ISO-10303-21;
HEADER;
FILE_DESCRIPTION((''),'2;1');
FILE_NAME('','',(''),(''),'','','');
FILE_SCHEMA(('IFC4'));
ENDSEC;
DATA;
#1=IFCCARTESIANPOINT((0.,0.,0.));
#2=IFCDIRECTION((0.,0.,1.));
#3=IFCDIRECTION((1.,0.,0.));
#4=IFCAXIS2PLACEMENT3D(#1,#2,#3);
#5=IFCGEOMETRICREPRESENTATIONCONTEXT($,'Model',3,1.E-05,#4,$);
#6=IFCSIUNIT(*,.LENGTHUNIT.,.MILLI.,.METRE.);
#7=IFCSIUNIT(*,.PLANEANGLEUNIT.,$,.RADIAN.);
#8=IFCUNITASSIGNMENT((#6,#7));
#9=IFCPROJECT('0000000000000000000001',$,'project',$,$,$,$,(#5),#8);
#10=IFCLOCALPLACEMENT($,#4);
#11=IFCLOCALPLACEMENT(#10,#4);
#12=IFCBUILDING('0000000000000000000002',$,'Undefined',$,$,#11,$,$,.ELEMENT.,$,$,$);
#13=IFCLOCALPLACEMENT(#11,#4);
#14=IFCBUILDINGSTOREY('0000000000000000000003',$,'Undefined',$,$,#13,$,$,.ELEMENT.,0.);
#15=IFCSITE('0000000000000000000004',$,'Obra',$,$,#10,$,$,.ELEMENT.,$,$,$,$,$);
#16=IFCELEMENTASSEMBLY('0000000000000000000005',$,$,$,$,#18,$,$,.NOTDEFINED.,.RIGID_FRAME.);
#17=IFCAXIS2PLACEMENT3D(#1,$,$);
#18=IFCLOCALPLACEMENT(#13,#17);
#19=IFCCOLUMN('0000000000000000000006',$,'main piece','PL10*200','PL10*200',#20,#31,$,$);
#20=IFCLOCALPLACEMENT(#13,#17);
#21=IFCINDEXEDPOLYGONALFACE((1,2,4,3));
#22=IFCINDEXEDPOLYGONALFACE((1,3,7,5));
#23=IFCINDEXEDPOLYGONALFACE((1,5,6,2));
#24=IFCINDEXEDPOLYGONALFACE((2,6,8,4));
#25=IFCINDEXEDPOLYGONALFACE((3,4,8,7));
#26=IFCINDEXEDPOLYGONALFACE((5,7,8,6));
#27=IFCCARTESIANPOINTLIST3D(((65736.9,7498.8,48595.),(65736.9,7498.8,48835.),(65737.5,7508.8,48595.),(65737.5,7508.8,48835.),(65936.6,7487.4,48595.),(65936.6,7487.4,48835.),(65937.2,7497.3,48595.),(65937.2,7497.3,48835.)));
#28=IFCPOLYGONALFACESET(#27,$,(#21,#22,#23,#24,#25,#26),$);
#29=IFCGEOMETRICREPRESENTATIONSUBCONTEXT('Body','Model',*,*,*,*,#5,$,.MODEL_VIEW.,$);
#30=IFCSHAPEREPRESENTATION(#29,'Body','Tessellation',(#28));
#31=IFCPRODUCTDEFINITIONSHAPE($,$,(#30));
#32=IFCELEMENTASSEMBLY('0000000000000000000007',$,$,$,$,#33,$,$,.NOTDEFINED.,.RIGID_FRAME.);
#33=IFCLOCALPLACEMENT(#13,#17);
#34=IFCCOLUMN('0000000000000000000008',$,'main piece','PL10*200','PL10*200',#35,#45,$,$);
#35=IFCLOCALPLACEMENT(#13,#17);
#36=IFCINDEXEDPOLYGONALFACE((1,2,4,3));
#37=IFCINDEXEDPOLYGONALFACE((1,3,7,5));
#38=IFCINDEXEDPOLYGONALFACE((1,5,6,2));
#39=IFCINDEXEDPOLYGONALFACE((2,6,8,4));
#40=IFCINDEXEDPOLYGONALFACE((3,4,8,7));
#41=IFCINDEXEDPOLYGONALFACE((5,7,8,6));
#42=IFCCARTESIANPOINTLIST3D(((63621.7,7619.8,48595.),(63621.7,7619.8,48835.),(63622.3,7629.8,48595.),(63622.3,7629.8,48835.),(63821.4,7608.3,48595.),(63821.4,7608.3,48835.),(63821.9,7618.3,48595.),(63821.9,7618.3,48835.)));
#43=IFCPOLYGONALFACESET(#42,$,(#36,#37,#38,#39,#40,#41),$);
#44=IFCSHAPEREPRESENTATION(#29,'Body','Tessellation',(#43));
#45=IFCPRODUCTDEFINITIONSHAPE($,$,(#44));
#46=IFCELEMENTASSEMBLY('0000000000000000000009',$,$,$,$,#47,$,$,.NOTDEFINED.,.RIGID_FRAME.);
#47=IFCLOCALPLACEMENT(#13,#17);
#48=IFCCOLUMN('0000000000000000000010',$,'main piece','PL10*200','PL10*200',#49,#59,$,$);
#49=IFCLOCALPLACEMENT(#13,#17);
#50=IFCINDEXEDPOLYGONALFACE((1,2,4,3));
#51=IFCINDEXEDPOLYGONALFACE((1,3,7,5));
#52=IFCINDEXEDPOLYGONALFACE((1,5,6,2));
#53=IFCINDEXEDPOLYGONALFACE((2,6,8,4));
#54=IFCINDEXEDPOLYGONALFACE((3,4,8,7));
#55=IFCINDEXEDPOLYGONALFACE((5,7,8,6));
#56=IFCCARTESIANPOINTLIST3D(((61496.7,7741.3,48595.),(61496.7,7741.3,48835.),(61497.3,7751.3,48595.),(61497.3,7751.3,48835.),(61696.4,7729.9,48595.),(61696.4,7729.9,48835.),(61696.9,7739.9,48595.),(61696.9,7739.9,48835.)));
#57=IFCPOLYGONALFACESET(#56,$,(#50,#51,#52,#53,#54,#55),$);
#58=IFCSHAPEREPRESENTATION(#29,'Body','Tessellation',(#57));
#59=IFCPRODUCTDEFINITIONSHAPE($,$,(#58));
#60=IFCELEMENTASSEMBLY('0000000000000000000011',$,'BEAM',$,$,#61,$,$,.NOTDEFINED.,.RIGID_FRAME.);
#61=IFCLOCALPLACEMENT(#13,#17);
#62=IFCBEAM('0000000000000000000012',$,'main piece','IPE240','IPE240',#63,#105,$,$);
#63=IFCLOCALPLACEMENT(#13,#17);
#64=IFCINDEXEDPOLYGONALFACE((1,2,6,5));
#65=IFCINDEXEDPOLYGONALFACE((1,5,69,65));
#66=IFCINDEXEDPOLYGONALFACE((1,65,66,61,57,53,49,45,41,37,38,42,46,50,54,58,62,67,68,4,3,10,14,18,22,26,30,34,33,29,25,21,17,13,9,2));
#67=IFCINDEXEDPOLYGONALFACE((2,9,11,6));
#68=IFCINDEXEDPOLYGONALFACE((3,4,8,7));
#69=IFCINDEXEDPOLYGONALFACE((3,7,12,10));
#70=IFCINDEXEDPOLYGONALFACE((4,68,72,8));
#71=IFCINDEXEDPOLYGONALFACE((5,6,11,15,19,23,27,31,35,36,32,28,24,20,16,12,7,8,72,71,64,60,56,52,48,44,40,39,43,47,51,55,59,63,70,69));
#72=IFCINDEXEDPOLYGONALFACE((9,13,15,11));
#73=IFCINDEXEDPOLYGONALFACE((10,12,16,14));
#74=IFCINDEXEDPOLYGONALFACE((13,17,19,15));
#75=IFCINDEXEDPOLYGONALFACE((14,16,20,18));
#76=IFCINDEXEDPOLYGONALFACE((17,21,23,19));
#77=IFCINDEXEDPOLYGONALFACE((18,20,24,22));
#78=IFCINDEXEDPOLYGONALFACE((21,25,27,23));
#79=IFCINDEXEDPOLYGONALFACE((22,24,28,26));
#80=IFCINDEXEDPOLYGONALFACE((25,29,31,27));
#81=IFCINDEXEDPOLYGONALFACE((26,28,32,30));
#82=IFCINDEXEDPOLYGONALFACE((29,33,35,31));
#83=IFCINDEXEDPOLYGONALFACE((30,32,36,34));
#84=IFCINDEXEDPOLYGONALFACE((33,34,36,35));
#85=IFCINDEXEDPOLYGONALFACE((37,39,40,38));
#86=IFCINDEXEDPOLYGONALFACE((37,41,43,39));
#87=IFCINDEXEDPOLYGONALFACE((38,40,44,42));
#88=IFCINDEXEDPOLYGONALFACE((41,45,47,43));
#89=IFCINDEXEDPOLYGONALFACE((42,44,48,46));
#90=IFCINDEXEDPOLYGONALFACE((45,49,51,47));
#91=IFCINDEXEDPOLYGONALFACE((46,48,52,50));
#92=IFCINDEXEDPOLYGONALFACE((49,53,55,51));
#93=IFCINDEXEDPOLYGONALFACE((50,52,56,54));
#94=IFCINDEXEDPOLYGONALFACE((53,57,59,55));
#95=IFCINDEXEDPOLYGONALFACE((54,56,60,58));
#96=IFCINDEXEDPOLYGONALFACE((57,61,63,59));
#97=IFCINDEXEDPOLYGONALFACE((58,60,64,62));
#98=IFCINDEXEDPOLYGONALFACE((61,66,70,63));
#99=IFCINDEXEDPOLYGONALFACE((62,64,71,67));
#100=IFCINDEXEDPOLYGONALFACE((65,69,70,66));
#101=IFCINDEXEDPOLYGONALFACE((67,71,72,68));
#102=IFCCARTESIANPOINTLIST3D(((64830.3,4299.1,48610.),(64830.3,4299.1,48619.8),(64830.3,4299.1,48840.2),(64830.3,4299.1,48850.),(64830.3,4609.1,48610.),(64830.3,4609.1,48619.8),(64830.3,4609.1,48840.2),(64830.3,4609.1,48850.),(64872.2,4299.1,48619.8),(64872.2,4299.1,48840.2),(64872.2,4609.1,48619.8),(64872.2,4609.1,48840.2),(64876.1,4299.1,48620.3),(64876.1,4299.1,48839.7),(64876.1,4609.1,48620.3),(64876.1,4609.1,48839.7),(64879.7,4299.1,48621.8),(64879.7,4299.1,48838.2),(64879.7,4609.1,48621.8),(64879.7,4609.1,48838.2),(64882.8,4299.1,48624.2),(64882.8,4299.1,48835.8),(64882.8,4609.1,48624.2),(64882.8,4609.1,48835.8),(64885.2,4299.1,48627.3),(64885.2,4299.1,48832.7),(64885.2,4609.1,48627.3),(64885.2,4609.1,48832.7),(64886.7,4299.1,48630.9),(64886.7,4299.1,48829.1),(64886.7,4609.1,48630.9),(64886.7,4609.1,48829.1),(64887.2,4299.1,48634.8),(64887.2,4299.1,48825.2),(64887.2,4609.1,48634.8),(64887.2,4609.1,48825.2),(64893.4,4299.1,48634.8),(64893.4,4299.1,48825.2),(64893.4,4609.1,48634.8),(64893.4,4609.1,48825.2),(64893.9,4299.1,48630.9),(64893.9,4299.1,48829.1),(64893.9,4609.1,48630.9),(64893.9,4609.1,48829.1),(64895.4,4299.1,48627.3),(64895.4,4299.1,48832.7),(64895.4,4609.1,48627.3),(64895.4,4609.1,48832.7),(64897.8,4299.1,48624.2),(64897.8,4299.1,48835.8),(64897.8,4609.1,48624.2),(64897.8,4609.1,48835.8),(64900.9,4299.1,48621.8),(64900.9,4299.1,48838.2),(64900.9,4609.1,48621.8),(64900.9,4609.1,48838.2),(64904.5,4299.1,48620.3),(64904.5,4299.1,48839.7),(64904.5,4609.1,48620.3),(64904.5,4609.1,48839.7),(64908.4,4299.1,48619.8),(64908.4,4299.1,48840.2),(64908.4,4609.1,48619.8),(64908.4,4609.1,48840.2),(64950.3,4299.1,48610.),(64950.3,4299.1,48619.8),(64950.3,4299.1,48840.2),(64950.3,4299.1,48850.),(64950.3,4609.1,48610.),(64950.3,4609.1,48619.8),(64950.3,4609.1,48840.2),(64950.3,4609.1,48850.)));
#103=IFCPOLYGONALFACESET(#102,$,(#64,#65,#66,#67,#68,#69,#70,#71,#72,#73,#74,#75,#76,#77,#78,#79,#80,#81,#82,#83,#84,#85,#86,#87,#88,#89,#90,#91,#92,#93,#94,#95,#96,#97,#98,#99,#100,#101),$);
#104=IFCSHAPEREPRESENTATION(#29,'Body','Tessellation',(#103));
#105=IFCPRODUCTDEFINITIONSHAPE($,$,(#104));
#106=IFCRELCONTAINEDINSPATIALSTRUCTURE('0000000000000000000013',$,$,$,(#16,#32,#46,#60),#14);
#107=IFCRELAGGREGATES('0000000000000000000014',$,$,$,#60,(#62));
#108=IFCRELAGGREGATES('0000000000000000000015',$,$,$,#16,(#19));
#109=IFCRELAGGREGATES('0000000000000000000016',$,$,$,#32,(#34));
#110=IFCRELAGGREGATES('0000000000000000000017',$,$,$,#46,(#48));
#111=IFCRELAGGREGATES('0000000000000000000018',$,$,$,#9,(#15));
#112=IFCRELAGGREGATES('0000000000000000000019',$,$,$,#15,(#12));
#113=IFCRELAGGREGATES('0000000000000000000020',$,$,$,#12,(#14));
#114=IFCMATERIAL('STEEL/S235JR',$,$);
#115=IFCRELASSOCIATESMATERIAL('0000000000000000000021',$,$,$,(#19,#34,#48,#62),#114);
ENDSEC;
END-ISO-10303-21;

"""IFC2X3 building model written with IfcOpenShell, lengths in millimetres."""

from ifc_helpers import new_model, si_unit, frame, origin_with_axes, origin_2d_with_axis, place, context, subcontext, project, spatial, rectangle, i_section, extrude, material, element, aggregate, save


model = new_model("IFC2X3")

# Units and contexts
model_context = context("Model", 3, precision=1e-05, world=origin_with_axes())
body_context = subcontext(model_context, "Body", "Model", "MODEL_VIEW")
ifc_project = project(units=[si_unit("LENGTHUNIT", "METRE", prefix="MILLI"), si_unit("PLANEANGLEUNIT", "RADIAN")], contexts=[model_context])

# Site, building, storey
site_placement = place(None, origin_with_axes())
site = spatial("IfcSite", under=ifc_project, at=site_placement, Name="Obra", CompositionType="ELEMENT")
building_placement = place(site_placement, origin_with_axes())
building = spatial("IfcBuilding", under=site, at=building_placement, Name="Undefined", CompositionType="ELEMENT")
storey_placement = place(building_placement, origin_with_axes())
storey = spatial("IfcBuildingStorey", under=building, at=storey_placement, Name="Undefined", CompositionType="ELEMENT", Elevation=0.0)

# Element assemblies, columns
assembly_1_placement = place(storey_placement, origin_with_axes())
assembly_1 = element("IfcElementAssembly", 1, at=assembly_1_placement, inside=storey, AssemblyPlace="NOTDEFINED", PredefinedType="RIGID_FRAME")
ifc_material_1 = material(Name="STEEL/S235JR")
column_1_placement = place(assembly_1_placement, frame((65837.0, 7498.1, 48595.0), z_axis=(0.0, 0.0, 1.0), x_axis=(-0.998368, 0.05711, 0.0)))
column_1 = element("IfcColumn", 2, at=column_1_placement, material=ifc_material_1, Name="main piece", Description="PL10*200", ObjectType="PL10*200", context=body_context, shape_type="SweptSolid", body=[
    extrude(rectangle(XDim=10.0, YDim=200.0, at=origin_2d_with_axis()), frame((0.0, 0.0, 240.0), z_axis=(0.0, 0.0, -1.0), x_axis=(0.0, 1.0, 0.0)), (0.0, 0.0, 1.0), 240.0),
])
assembly_2_placement = place(storey_placement, origin_with_axes())
assembly_2 = element("IfcElementAssembly", 3, at=assembly_2_placement, inside=storey, AssemblyPlace="NOTDEFINED", PredefinedType="RIGID_FRAME")
column_2_placement = place(assembly_2_placement, frame((63721.8, 7619.1, 48595.0), z_axis=(0.0, 0.0, 1.0), x_axis=(-0.998368, 0.05711, 0.0)))
column_2 = element("IfcColumn", 4, at=column_2_placement, material=ifc_material_1, Name="main piece", Description="PL10*200", ObjectType="PL10*200", context=body_context, shape_type="SweptSolid", body=[
    extrude(rectangle(XDim=10.0, YDim=200.0, at=origin_2d_with_axis()), frame((0.0, 0.0, 240.0), z_axis=(0.0, 0.0, -1.0), x_axis=(0.0, 1.0, 0.0)), (0.0, 0.0, 1.0), 240.0),
])
assembly_3_placement = place(storey_placement, origin_with_axes())
assembly_3 = element("IfcElementAssembly", 5, at=assembly_3_placement, inside=storey, AssemblyPlace="NOTDEFINED", PredefinedType="RIGID_FRAME")
column_3_placement = place(assembly_3_placement, frame((61596.8, 7740.6, 48595.0), z_axis=(0.0, 0.0, 1.0), x_axis=(-0.998368, 0.05711, 0.0)))
column_3 = element("IfcColumn", 6, at=column_3_placement, material=ifc_material_1, Name="main piece", Description="PL10*200", ObjectType="PL10*200", context=body_context, shape_type="SweptSolid", body=[
    extrude(rectangle(XDim=10.0, YDim=200.0, at=origin_2d_with_axis()), frame((0.0, 0.0, 240.0), z_axis=(0.0, 0.0, -1.0), x_axis=(0.0, 1.0, 0.0)), (0.0, 0.0, 1.0), 240.0),
])

# Element assembly, beam
assembly_4_placement = place(storey_placement, origin_with_axes())
assembly_4 = element("IfcElementAssembly", 7, at=assembly_4_placement, inside=storey, Name="BEAM", AssemblyPlace="NOTDEFINED", PredefinedType="RIGID_FRAME")
beam_1_placement = place(assembly_4_placement, frame((64890.3, 4299.1, 48730.0), z_axis=(0.0, 0.0, 1.0), x_axis=(0.0, 1.0, 0.0)))
beam_1 = element("IfcBeam", 8, at=beam_1_placement, material=ifc_material_1, Name="main piece", Description="IPE240", ObjectType="IPE240", context=body_context, shape_type="SweptSolid", body=[
    extrude(i_section(OverallWidth=120.0, OverallDepth=240.0, WebThickness=6.2, FlangeThickness=9.8, FilletRadius=15.0, at=origin_2d_with_axis()), frame((310.0, 0.0, 0.0), z_axis=(-1.0, 0.0, 0.0), x_axis=(0.0, -1.0, 0.0)), (0.0, 0.0, 1.0), 310.0),
])
aggregate(assembly_4, [beam_1])

aggregate(assembly_1, [column_1])
aggregate(assembly_2, [column_2])
aggregate(assembly_3, [column_3])

save(model, "model.ifc")
